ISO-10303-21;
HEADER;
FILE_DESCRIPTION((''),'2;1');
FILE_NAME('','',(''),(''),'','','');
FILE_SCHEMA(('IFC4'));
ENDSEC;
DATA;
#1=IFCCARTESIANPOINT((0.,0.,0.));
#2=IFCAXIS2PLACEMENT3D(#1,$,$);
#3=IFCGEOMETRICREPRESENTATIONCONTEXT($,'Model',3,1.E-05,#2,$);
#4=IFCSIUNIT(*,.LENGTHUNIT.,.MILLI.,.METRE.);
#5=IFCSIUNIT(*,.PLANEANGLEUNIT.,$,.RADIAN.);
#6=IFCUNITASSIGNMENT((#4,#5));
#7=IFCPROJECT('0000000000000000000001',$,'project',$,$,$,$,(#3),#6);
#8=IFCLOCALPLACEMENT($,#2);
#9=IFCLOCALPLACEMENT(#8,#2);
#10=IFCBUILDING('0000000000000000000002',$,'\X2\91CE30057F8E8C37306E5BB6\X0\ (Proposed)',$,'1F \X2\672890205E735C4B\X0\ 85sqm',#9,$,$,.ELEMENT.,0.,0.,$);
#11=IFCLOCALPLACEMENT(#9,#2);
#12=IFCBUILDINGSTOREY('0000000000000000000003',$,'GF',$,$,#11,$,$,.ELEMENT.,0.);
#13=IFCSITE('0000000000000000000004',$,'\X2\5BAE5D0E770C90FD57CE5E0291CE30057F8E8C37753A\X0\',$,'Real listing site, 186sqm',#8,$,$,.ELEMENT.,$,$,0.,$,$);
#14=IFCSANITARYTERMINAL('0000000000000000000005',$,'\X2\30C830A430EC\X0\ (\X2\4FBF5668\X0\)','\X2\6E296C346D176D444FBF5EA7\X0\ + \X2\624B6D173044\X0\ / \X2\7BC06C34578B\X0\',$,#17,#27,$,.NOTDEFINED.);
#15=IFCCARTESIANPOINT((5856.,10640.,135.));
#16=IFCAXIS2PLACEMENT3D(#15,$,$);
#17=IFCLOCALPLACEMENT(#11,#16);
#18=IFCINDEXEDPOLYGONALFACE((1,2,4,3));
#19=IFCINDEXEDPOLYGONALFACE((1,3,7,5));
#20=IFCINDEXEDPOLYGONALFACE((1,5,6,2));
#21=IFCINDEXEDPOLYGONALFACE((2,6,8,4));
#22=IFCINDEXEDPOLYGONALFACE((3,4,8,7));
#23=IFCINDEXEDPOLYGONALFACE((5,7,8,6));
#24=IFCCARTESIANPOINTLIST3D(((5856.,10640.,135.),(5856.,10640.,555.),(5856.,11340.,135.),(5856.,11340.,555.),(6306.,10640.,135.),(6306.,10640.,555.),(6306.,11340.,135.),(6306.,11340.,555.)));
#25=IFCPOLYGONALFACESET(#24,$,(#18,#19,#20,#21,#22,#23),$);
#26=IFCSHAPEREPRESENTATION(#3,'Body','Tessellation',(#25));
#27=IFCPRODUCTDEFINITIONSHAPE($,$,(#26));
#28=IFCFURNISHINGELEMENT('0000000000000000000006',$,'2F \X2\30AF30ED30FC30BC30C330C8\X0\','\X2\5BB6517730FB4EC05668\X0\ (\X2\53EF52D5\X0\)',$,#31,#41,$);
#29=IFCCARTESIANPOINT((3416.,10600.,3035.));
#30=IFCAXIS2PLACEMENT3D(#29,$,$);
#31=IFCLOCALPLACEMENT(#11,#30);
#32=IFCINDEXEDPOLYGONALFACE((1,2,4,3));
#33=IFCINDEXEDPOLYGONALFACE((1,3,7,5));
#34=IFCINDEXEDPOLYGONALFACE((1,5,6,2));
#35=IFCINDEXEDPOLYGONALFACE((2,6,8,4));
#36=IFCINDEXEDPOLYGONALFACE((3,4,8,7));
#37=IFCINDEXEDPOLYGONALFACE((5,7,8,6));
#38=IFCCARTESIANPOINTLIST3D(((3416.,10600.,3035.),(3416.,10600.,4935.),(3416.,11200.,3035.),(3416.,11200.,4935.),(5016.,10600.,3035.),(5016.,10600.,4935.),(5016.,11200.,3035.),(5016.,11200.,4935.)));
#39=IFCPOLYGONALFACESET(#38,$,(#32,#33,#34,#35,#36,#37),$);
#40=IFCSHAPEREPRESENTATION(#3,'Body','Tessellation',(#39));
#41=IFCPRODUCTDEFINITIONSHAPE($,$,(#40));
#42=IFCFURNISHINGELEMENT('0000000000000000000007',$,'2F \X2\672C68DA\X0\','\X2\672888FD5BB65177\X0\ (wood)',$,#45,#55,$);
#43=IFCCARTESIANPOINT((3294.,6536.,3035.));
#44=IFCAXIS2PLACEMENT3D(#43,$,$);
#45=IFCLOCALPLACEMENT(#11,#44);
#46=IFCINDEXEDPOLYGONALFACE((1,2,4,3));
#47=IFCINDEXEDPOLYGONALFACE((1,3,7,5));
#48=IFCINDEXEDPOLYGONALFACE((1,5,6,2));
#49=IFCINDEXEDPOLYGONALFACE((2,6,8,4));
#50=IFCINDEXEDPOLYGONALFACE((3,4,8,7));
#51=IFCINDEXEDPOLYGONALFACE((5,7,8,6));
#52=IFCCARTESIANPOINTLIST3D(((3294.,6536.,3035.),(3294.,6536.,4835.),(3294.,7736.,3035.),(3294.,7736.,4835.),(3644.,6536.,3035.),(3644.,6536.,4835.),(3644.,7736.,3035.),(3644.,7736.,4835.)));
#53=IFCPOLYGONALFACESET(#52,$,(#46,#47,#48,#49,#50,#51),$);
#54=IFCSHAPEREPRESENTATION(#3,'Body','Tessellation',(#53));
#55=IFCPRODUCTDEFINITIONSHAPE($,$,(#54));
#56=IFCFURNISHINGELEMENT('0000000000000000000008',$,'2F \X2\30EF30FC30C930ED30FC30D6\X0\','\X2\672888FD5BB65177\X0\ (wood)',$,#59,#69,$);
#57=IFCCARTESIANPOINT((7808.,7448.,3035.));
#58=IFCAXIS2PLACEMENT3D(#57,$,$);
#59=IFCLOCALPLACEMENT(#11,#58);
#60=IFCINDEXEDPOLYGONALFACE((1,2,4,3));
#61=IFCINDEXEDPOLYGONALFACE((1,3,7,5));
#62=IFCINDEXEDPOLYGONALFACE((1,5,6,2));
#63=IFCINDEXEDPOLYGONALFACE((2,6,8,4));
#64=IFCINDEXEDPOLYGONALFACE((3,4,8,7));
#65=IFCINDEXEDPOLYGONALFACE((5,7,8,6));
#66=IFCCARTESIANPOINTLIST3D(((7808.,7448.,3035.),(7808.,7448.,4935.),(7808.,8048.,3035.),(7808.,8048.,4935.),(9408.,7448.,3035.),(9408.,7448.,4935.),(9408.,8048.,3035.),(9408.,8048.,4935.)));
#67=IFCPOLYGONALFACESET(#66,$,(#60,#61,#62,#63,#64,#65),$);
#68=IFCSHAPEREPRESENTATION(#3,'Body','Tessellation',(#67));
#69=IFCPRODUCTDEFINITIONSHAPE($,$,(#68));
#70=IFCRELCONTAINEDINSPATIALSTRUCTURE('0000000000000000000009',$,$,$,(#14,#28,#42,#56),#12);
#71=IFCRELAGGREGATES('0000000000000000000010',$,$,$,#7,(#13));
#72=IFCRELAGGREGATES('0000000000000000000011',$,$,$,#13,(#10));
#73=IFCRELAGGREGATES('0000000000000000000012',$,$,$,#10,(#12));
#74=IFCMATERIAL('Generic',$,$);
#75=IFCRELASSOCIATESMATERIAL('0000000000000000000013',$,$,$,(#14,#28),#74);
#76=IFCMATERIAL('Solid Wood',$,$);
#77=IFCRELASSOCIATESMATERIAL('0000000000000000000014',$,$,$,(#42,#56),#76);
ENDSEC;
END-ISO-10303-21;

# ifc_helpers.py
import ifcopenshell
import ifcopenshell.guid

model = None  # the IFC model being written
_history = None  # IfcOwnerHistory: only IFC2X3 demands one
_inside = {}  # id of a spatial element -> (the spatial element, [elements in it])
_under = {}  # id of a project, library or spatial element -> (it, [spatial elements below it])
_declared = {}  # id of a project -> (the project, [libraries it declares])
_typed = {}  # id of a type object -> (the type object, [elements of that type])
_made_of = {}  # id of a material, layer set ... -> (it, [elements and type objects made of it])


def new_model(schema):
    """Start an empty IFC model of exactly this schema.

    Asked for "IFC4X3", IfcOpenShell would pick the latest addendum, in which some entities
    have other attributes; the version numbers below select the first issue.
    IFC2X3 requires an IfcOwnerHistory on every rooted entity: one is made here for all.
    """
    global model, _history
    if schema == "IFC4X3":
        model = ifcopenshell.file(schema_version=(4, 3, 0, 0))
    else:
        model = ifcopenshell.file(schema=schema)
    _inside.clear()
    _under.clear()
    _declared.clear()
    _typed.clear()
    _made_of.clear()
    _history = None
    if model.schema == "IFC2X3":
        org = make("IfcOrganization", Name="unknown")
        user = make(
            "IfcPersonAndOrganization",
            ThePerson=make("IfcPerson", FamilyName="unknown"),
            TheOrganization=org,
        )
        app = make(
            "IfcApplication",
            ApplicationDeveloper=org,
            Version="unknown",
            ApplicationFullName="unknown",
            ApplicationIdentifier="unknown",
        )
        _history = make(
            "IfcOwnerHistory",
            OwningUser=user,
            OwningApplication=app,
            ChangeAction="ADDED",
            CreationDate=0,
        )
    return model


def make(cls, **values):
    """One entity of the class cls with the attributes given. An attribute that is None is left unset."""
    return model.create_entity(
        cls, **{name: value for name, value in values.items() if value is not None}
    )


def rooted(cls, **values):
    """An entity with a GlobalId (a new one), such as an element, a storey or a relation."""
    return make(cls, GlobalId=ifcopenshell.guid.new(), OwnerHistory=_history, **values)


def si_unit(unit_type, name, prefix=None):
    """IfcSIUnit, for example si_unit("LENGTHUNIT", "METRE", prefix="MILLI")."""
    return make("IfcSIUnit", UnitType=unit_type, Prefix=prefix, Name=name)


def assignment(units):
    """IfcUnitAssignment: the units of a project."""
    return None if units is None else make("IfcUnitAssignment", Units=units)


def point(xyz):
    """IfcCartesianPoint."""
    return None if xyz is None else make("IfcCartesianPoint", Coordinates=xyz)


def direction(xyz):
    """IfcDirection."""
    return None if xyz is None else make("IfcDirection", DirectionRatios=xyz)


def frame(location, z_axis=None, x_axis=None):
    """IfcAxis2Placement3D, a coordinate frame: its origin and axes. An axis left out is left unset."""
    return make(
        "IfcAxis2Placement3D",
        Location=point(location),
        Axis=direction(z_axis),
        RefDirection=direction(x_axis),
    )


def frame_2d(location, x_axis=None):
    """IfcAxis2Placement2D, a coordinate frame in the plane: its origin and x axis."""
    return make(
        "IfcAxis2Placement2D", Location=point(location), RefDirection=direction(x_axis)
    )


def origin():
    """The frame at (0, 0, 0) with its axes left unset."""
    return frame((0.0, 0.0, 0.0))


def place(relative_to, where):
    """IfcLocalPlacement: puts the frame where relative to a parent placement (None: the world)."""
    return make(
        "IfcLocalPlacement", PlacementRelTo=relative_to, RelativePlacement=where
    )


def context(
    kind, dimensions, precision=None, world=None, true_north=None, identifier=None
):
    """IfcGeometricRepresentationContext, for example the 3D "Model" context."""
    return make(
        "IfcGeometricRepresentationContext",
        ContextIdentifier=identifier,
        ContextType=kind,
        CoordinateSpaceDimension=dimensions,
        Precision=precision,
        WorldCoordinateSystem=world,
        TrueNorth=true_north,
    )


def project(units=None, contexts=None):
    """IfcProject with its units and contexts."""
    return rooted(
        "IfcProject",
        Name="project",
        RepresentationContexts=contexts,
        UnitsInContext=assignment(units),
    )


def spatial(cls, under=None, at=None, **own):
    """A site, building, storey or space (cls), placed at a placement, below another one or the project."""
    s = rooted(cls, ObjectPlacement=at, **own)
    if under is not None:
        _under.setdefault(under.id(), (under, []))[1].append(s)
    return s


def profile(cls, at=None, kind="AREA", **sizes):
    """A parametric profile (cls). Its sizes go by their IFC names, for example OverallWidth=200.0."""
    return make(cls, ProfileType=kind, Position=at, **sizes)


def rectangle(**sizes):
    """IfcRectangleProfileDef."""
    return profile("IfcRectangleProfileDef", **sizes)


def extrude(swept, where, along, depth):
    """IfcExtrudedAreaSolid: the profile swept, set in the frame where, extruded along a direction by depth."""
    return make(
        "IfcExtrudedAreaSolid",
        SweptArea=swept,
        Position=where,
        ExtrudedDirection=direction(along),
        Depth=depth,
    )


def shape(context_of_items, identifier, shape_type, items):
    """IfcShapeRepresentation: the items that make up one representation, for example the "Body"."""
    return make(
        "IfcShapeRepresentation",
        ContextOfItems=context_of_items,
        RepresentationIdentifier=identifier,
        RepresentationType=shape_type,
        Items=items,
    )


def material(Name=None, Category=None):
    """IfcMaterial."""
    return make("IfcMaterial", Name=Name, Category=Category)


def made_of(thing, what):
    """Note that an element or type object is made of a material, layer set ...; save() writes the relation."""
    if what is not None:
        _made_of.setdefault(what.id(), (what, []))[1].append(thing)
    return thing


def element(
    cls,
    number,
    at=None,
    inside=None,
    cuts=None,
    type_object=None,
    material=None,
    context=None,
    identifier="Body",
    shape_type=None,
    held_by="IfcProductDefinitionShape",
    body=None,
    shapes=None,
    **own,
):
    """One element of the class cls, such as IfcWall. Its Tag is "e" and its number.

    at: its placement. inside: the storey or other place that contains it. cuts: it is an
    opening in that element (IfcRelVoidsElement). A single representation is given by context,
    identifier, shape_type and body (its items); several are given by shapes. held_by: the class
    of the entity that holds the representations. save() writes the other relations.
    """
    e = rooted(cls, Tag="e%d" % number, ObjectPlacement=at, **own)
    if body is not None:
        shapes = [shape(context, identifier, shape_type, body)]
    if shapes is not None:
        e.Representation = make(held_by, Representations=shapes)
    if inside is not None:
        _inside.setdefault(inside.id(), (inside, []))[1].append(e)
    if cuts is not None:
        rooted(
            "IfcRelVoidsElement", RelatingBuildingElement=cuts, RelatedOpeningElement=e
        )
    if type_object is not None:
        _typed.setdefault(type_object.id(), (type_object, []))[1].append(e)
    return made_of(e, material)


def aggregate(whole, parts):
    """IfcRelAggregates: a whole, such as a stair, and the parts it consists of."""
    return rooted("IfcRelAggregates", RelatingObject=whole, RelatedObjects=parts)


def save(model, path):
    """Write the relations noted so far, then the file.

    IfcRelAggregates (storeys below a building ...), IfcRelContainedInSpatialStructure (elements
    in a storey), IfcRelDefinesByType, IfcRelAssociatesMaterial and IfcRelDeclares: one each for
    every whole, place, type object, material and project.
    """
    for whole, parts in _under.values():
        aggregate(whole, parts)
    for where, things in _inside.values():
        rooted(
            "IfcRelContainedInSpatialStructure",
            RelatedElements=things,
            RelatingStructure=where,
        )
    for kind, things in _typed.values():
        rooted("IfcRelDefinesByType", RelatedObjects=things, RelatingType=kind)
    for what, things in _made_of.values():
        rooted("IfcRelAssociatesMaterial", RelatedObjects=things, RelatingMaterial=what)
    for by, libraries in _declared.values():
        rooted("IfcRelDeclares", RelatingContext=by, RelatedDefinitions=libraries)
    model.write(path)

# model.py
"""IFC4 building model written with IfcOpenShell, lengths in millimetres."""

from ifc_helpers import new_model, si_unit, frame, frame_2d, origin, place, context, project, spatial, rectangle, extrude, material, element, save


model = new_model("IFC4")

# Units and contexts
model_context = context("Model", 3, precision=1e-05, world=origin())
ifc_project = project(units=[si_unit("LENGTHUNIT", "METRE", prefix="MILLI"), si_unit("PLANEANGLEUNIT", "RADIAN")], contexts=[model_context])

# Site, building, storey
site_placement = place(None, origin())
site = spatial("IfcSite", under=ifc_project, at=site_placement, Name="宮崎県都城市野々美谷町", ObjectType="Real listing site, 186sqm", CompositionType="ELEMENT", RefElevation=0.0)
building_placement = place(site_placement, origin())
building = spatial("IfcBuilding", under=site, at=building_placement, Name="野々美谷の家 (Proposed)", ObjectType="1F 木造平屋 85sqm", CompositionType="ELEMENT", ElevationOfRefHeight=0.0, ElevationOfTerrain=0.0)
storey_placement = place(building_placement, origin())
storey = spatial("IfcBuildingStorey", under=building, at=storey_placement, Name="GF", CompositionType="ELEMENT", Elevation=0.0)

# Shared definitions
ifc_material_1 = material(Name="Solid Wood")

# Shared definitions
ifc_material_2 = material(Name="Generic")

# Sanitary terminal
sanitary_terminal_placement = place(storey_placement, frame((5856.0, 10640.0, 135.0)))
element("IfcSanitaryTerminal", 1, at=sanitary_terminal_placement, inside=storey, material=ifc_material_2, Name="トイレ (便器)", Description="温水洗浄便座 + 手洗い / 節水型", PredefinedType="NOTDEFINED", context=model_context, shape_type="SweptSolid", body=[
    extrude(rectangle(XDim=450.0, YDim=700.0, at=frame_2d((225.0, 350.0))), frame((5856.0, 10640.0, 135.0)), (0.0, 0.0, 1.0), 420.0),
])

# Furnishing elements
furnishing_1_placement = place(storey_placement, frame((3416.0, 10600.0, 3035.0)))
element("IfcFurnishingElement", 2, at=furnishing_1_placement, inside=storey, material=ifc_material_2, Name="2F クローゼット", Description="家具・什器 (可動)", context=model_context, shape_type="SweptSolid", body=[
    extrude(rectangle(XDim=1600.0, YDim=600.0, at=frame_2d((800.0, 300.0))), frame((3416.0, 10600.0, 3035.0)), (0.0, 0.0, 1.0), 1900.0),
])
furnishing_2_placement = place(storey_placement, frame((3294.0, 6536.0, 3035.0)))
element("IfcFurnishingElement", 3, at=furnishing_2_placement, inside=storey, material=ifc_material_1, Name="2F 本棚", Description="木製家具 (wood)", context=model_context, shape_type="SweptSolid", body=[
    extrude(rectangle(XDim=350.0, YDim=1200.0, at=frame_2d((175.0, 600.0))), frame((3294.0, 6536.0, 3035.0)), (0.0, 0.0, 1.0), 1800.0),
])
furnishing_3_placement = place(storey_placement, frame((7808.0, 7448.0, 3035.0)))
element("IfcFurnishingElement", 4, at=furnishing_3_placement, inside=storey, material=ifc_material_1, Name="2F ワードローブ", Description="木製家具 (wood)", context=model_context, shape_type="SweptSolid", body=[
    extrude(rectangle(XDim=1600.0, YDim=600.0, at=frame_2d((800.0, 300.0))), frame((7808.0, 7448.0, 3035.0)), (0.0, 0.0, 1.0), 1900.0),
])

save(model, "model.ifc")
